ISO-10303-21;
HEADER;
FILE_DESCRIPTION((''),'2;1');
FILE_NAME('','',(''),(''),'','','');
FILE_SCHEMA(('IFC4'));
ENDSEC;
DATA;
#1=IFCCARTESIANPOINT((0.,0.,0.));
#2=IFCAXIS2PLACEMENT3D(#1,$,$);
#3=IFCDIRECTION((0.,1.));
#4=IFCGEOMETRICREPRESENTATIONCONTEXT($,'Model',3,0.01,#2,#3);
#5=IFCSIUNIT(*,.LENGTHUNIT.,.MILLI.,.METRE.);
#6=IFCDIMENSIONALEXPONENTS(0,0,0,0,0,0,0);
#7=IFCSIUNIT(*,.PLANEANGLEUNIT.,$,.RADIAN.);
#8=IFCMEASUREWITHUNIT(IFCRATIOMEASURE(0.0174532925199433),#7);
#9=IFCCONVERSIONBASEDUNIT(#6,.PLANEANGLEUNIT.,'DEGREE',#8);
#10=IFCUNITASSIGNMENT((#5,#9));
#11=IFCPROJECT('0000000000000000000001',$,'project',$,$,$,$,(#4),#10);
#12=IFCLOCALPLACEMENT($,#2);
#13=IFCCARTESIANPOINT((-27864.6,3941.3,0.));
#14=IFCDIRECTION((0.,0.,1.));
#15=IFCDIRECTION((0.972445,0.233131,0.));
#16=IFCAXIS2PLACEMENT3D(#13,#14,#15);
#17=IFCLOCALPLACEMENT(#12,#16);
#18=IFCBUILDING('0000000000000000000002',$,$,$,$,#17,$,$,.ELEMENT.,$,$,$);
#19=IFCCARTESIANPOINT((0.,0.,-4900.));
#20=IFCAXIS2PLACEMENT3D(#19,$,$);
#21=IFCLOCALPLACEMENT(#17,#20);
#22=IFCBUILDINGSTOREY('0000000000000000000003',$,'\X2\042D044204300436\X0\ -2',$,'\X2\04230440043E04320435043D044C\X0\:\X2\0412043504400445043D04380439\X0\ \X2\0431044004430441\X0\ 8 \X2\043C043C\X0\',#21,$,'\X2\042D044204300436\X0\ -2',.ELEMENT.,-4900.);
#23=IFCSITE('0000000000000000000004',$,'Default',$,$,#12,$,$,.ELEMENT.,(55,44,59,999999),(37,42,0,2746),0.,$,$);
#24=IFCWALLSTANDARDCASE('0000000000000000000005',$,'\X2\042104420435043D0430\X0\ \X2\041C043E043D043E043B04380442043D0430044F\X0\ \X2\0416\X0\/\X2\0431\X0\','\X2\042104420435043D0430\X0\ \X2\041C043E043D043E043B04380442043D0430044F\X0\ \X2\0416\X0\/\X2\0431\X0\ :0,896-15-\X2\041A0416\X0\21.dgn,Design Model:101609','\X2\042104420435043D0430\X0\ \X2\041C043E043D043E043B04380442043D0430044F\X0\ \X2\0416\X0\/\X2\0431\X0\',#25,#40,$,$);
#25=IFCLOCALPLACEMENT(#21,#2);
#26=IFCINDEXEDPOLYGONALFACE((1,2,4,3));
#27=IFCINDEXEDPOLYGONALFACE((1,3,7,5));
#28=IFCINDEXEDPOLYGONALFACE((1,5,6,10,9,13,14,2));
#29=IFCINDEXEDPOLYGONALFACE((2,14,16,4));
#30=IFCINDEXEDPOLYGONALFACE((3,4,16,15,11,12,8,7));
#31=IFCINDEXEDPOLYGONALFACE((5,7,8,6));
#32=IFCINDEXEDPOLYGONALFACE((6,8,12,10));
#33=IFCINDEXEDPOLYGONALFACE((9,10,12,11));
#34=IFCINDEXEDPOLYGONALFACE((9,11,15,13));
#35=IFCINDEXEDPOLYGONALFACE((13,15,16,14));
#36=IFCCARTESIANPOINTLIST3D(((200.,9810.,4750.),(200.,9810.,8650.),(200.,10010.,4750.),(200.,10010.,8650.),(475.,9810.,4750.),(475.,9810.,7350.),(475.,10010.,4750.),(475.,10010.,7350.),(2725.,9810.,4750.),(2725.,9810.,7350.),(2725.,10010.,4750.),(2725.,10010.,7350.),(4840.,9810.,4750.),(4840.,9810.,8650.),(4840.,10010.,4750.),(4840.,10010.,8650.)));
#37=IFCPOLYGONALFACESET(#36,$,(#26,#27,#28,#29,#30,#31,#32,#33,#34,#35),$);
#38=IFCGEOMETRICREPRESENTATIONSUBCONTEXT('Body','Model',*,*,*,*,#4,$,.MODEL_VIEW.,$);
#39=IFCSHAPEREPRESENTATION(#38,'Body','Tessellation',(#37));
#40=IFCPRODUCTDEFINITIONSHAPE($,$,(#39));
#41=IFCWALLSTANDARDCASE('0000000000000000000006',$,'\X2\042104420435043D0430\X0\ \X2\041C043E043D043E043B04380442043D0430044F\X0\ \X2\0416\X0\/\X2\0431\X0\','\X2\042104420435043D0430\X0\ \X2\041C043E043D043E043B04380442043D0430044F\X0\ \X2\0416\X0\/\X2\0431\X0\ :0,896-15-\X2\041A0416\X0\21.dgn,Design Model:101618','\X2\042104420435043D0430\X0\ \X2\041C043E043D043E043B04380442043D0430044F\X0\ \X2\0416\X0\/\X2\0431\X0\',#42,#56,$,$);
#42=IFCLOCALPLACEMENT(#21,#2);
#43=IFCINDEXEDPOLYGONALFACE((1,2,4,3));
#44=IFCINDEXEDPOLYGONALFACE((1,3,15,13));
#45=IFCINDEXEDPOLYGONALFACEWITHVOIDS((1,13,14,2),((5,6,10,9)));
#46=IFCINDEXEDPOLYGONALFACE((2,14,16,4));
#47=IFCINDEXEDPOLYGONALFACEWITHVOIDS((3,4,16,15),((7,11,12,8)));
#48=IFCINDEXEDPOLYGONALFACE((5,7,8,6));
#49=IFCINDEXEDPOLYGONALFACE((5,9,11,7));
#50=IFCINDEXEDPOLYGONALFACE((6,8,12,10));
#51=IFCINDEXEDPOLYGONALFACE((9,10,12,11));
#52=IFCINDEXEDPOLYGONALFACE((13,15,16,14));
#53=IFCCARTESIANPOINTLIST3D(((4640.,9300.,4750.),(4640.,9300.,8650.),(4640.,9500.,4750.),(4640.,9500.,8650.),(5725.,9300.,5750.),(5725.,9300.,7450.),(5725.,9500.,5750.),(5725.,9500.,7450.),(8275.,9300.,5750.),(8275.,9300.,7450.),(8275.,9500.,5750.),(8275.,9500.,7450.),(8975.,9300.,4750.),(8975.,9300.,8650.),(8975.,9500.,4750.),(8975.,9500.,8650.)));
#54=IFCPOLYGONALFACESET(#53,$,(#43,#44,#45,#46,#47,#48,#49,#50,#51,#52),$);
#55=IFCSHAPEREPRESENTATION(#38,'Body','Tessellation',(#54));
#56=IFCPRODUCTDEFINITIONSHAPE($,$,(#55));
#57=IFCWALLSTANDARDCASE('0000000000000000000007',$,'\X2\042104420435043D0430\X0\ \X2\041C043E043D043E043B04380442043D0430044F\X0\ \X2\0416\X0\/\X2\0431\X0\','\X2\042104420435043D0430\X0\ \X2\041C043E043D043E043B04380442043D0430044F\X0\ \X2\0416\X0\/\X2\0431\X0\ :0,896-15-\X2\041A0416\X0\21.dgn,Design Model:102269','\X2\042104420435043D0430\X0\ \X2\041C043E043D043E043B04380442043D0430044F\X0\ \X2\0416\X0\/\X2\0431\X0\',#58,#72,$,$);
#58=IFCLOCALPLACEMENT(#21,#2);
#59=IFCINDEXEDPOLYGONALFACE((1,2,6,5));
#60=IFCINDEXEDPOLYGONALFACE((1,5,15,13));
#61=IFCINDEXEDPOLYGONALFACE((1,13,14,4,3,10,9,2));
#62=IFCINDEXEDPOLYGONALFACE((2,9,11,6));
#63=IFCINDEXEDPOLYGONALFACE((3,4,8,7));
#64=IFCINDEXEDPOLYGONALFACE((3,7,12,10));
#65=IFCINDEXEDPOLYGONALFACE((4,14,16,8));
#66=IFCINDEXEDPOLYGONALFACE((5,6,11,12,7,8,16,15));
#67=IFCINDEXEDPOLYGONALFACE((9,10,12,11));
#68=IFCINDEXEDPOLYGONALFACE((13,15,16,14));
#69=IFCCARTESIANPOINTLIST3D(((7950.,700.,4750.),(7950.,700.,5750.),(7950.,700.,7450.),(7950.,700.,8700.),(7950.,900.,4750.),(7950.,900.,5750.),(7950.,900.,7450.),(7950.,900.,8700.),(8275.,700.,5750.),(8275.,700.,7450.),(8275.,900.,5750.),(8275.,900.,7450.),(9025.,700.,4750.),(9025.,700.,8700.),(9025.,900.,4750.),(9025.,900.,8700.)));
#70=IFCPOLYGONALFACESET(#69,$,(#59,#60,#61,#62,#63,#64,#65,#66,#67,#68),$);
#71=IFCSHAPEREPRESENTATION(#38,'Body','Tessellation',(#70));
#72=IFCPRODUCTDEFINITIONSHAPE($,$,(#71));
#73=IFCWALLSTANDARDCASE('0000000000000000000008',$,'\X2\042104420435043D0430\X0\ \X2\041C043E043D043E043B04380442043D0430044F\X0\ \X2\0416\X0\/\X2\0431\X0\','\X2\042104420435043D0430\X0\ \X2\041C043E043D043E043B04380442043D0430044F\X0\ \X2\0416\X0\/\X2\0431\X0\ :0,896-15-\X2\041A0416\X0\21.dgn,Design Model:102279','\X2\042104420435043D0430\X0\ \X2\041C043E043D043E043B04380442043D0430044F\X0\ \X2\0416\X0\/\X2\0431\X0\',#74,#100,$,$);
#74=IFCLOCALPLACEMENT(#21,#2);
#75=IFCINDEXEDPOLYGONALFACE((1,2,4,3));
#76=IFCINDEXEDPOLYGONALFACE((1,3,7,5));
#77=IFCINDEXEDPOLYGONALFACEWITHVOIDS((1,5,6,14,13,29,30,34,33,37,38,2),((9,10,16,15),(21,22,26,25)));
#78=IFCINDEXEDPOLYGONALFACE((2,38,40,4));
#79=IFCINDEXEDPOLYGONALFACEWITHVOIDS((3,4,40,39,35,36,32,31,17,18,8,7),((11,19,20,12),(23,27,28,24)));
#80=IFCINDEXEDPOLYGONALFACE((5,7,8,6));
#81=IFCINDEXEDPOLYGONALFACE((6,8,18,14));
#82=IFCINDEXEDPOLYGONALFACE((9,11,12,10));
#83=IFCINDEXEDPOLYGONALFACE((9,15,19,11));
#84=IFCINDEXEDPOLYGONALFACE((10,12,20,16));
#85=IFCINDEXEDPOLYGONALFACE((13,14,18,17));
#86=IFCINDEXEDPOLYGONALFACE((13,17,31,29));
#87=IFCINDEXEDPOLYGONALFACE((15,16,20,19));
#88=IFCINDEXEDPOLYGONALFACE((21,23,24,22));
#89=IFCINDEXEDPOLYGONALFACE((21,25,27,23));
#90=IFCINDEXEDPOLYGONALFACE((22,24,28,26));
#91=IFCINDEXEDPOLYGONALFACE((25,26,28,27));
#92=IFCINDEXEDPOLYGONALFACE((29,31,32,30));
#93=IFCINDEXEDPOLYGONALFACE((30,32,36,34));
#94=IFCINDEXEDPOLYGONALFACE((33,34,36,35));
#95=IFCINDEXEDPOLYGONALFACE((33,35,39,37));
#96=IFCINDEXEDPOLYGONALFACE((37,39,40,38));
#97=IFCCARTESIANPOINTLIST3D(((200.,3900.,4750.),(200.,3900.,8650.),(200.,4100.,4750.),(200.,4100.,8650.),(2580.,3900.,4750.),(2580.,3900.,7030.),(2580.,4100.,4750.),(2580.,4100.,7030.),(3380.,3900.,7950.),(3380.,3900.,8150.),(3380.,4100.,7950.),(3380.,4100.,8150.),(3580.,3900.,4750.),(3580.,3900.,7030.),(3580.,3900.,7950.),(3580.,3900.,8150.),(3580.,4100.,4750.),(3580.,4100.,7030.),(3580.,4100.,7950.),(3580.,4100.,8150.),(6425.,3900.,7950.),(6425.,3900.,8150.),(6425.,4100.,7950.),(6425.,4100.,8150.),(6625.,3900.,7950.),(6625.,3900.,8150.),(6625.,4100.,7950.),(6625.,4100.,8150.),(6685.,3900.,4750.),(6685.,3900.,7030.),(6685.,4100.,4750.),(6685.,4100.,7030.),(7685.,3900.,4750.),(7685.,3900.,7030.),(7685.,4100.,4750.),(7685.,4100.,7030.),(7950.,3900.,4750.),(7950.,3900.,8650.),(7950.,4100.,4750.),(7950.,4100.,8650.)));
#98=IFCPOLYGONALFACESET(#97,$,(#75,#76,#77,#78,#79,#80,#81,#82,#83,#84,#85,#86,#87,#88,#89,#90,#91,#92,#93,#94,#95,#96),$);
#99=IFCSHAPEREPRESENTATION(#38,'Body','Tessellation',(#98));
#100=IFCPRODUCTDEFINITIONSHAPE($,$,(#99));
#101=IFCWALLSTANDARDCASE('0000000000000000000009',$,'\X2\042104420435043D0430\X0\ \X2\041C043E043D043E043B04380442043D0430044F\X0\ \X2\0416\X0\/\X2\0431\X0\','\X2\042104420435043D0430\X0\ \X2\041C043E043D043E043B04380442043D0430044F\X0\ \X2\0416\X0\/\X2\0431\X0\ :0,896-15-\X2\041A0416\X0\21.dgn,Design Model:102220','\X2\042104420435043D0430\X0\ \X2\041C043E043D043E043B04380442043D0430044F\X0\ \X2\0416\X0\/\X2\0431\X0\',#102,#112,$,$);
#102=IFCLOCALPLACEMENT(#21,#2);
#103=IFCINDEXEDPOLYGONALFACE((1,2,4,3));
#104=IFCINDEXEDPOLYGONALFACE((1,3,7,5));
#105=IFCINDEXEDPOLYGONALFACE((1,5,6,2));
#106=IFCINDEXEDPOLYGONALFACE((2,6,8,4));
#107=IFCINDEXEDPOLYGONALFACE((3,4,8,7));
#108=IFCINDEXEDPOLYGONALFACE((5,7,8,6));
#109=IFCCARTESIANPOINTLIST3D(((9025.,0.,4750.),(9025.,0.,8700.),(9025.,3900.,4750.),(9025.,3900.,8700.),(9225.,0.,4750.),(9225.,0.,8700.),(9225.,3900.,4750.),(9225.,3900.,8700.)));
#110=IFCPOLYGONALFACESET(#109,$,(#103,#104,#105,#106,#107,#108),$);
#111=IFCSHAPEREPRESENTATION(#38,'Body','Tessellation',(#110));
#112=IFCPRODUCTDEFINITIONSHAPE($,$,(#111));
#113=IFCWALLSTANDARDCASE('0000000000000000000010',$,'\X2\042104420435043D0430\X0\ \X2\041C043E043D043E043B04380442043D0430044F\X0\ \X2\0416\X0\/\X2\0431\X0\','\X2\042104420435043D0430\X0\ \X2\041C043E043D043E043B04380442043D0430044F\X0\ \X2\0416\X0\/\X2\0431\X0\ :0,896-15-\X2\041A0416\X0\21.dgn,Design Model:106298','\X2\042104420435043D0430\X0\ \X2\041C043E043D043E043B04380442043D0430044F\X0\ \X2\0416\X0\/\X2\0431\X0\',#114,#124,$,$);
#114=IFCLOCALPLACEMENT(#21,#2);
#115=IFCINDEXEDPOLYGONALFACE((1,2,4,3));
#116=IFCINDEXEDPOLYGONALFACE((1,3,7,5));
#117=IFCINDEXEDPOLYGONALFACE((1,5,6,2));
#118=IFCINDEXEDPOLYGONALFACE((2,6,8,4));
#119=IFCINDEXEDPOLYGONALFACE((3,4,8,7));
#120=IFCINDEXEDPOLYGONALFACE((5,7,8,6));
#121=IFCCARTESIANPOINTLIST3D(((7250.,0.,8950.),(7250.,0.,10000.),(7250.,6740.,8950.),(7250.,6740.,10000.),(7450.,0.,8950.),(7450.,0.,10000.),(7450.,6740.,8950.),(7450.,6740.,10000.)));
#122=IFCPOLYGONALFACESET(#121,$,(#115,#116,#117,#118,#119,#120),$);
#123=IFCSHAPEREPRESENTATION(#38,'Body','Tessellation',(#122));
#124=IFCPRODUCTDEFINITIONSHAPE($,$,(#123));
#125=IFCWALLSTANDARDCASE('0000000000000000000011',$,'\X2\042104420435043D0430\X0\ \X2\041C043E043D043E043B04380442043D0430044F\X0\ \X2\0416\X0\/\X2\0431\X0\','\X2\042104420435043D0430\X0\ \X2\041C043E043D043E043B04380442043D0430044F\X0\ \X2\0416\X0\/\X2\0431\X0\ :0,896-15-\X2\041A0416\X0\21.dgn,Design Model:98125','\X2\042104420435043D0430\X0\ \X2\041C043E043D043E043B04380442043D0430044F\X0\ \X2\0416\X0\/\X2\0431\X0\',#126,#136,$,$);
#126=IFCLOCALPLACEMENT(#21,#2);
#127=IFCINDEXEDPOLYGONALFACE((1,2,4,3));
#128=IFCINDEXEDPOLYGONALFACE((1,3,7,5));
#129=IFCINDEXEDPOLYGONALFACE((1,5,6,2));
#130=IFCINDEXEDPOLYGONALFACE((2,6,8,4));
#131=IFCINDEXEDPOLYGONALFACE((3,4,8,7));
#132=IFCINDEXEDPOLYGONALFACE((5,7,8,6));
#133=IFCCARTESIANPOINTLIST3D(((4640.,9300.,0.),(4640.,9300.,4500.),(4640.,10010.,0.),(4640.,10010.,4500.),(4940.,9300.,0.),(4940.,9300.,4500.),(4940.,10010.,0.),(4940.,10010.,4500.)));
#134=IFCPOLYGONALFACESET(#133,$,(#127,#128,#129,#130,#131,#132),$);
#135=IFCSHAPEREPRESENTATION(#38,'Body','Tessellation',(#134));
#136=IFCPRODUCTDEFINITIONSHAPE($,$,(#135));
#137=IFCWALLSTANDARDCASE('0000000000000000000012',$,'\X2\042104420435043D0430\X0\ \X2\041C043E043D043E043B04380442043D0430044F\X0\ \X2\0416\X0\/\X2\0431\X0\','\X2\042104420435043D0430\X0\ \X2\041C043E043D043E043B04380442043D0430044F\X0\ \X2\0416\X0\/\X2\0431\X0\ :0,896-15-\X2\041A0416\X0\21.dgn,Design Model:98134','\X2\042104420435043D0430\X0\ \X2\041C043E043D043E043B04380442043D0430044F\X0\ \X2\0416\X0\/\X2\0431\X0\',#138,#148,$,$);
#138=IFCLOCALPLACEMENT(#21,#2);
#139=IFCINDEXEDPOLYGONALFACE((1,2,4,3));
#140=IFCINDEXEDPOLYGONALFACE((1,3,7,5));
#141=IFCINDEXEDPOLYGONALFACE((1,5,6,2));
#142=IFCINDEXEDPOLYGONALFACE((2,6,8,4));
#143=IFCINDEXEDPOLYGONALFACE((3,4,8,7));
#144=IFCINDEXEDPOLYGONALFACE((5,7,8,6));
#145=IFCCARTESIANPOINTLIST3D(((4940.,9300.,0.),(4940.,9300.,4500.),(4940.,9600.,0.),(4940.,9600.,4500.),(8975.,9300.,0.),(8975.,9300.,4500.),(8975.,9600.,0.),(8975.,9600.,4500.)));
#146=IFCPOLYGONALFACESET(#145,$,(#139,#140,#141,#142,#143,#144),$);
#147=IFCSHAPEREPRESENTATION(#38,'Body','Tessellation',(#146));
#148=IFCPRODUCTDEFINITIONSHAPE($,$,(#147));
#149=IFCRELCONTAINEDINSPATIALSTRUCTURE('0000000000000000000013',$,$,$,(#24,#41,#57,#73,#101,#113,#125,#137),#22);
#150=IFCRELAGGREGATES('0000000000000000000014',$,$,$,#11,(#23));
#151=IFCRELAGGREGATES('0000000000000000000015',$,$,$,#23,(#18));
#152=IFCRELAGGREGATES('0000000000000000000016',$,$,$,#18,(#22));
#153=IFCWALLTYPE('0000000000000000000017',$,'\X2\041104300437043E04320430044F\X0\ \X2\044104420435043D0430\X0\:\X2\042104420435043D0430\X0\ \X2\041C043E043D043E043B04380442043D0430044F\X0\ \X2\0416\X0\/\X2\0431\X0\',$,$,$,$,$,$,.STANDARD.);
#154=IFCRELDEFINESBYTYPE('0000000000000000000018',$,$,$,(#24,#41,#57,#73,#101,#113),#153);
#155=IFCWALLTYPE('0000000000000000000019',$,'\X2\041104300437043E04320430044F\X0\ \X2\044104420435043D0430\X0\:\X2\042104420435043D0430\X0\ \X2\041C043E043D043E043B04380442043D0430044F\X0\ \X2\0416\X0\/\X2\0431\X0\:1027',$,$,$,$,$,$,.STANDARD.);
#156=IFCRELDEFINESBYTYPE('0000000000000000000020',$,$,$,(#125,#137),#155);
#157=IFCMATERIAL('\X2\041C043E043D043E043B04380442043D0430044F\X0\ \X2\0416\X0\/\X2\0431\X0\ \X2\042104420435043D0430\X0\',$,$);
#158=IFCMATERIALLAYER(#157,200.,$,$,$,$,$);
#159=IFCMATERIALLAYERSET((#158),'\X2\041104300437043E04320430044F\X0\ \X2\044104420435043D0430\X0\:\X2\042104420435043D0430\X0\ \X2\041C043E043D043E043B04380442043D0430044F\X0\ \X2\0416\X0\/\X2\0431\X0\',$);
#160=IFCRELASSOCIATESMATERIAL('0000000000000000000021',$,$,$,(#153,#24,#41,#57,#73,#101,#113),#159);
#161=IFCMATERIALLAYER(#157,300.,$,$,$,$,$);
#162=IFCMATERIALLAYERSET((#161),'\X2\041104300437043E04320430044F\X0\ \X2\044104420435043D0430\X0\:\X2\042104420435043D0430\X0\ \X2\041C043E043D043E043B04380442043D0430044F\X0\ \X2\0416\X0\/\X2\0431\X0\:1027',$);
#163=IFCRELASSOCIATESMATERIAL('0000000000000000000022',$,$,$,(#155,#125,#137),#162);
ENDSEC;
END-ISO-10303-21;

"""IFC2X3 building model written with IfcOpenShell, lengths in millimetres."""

from ifc_helpers import new_model, entity, si_unit, converted_unit, direction, frame, frame_2d, origin, origin_2d_with_axis, place, context, subcontext, project, spatial, rectangle, extrude, material, layer, layer_set, layer_usage, type_object, element, save


model = new_model("IFC2X3")

# Units and contexts
model_context = context("Model", 3, precision=0.01, world=origin(), true_north=direction((0.0, 1.0)))
body_context = subcontext(model_context, "Body", "Model", "MODEL_VIEW")
ifc_project = project(units=[si_unit("LENGTHUNIT", "METRE", prefix="MILLI"), converted_unit("PLANEANGLEUNIT", "DEGREE", entity("IfcRatioMeasure", 0.0174532925199433), si_unit("PLANEANGLEUNIT", "RADIAN"), dimensions=[0, 0, 0, 0, 0, 0, 0])], contexts=[model_context])

# Site, building, storey
site_placement = place(None, origin())
site = spatial("IfcSite", under=ifc_project, at=site_placement, Name="Default", CompositionType="ELEMENT", RefLatitude=(55, 44, 59, 999999), RefLongitude=(37, 42, 0, 2746), RefElevation=0.0)
building_placement = place(site_placement, frame((-27864.6, 3941.3, 0.0), z_axis=(0.0, 0.0, 1.0), x_axis=(0.972445, 0.233131, 0.0)))
building = spatial("IfcBuilding", under=site, at=building_placement, CompositionType="ELEMENT")
storey_placement = place(building_placement, frame((0.0, 0.0, -4900.0)))
storey = spatial("IfcBuildingStorey", under=building, at=storey_placement, Name="Этаж -2", ObjectType="Уровень:Верхний брус 8 мм", LongName="Этаж -2", CompositionType="ELEMENT", Elevation=-4900.0)

# Walls, openings
ifc_material = material(Name="Монолитная Ж/б Стена")
ifc_layer_1 = layer(ifc_material, 200.0)
ifc_layer_set_1 = layer_set([ifc_layer_1], Name="Базовая стена:Стена Монолитная Ж/б")
ifc_layer_usage_1 = layer_usage(ifc_layer_set_1, "AXIS2", "NEGATIVE", 100.0)
wall_type_1 = type_object("IfcWallType", Name="Базовая стена:Стена Монолитная Ж/б", PredefinedType="STANDARD", material=ifc_layer_set_1)
wall_1_placement = place(storey_placement, frame((4840.0, 9910.0, 4750.0), z_axis=(0.0, 0.0, 1.0), x_axis=(-1.0, 0.0, 0.0)))
wall_1 = element("IfcWallStandardCase", 1, at=wall_1_placement, inside=storey, type_object=wall_type_1, material=ifc_layer_usage_1, Name="Стена Монолитная Ж/б", Description="Стена Монолитная Ж/б :0,896-15-КЖ21.dgn,Design Model:101609", ObjectType="Стена Монолитная Ж/б", context=body_context, shape_type="SweptSolid", body=[
    extrude(rectangle(XDim=4640.0, YDim=200.0, at=frame_2d((2320.0, 0.0), x_axis=(-1.0, 0.0))), origin(), (0.0, 0.0, 1.0), 3900.0),
])
opening_1_placement = place(wall_1_placement, origin())
element("IfcOpeningElement", 2, at=opening_1_placement, cuts=wall_1, ObjectType="Opening", context=body_context, shape_type="SweptSolid", body=[
    extrude(rectangle(XDim=2600.0, YDim=2250.0, at=origin_2d_with_axis()), frame((3240.0, -100.0, 1300.0), z_axis=(0.0, 1.0, 0.0), x_axis=(0.0, 0.0, -1.0)), (0.0, 0.0, 1.0), 200.0),
])
wall_2_placement = place(storey_placement, frame((8975.0, 9400.0, 4750.0), z_axis=(0.0, 0.0, 1.0), x_axis=(-1.0, 0.0, 0.0)))
wall_2 = element("IfcWallStandardCase", 3, at=wall_2_placement, inside=storey, type_object=wall_type_1, material=ifc_layer_usage_1, Name="Стена Монолитная Ж/б", Description="Стена Монолитная Ж/б :0,896-15-КЖ21.dgn,Design Model:101618", ObjectType="Стена Монолитная Ж/б", context=body_context, shape_type="SweptSolid", body=[
    extrude(rectangle(XDim=4335.0, YDim=200.0, at=frame_2d((2167.5, 0.0), x_axis=(-1.0, 0.0))), origin(), (0.0, 0.0, 1.0), 3900.0),
])
opening_2_placement = place(wall_2_placement, origin())
element("IfcOpeningElement", 4, at=opening_2_placement, cuts=wall_2, ObjectType="Opening", context=body_context, shape_type="SweptSolid", body=[
    extrude(rectangle(XDim=1700.0, YDim=2550.0, at=origin_2d_with_axis()), frame((1975.0, -100.0, 1850.0), z_axis=(0.0, 1.0, 0.0), x_axis=(0.0, 0.0, -1.0)), (0.0, 0.0, 1.0), 200.0),
])
wall_3_placement = place(storey_placement, frame((9025.0, 800.0, 4750.0), z_axis=(0.0, 0.0, 1.0), x_axis=(-1.0, 0.0, 0.0)))
wall_3 = element("IfcWallStandardCase", 5, at=wall_3_placement, inside=storey, type_object=wall_type_1, material=ifc_layer_usage_1, Name="Стена Монолитная Ж/б", Description="Стена Монолитная Ж/б :0,896-15-КЖ21.dgn,Design Model:102269", ObjectType="Стена Монолитная Ж/б", context=body_context, shape_type="SweptSolid", body=[
    extrude(rectangle(XDim=1075.0, YDim=200.0, at=frame_2d((537.5, 0.0), x_axis=(-1.0, 0.0))), origin(), (0.0, 0.0, 1.0), 3950.0),
])
opening_3_placement = place(wall_3_placement, origin())
element("IfcOpeningElement", 6, at=opening_3_placement, cuts=wall_3, ObjectType="Opening", context=body_context, shape_type="SweptSolid", body=[
    extrude(rectangle(XDim=1700.0, YDim=325.0, at=origin_2d_with_axis()), frame((912.5, -100.0, 1850.0), z_axis=(0.0, 1.0, 0.0), x_axis=(0.0, 0.0, -1.0)), (0.0, 0.0, 1.0), 200.0),
])

# Wall, openings
wall_4_placement = place(storey_placement, frame((7950.0, 4000.0, 4750.0), z_axis=(0.0, 0.0, 1.0), x_axis=(-1.0, 0.0, 0.0)))
wall_4 = element("IfcWallStandardCase", 7, at=wall_4_placement, inside=storey, type_object=wall_type_1, material=ifc_layer_usage_1, Name="Стена Монолитная Ж/б", Description="Стена Монолитная Ж/б :0,896-15-КЖ21.dgn,Design Model:102279", ObjectType="Стена Монолитная Ж/б", context=body_context, shape_type="SweptSolid", body=[
    extrude(rectangle(XDim=7750.0, YDim=200.0, at=frame_2d((3875.0, 0.0), x_axis=(-1.0, 0.0))), origin(), (0.0, 0.0, 1.0), 3900.0),
])
placement_1 = place(wall_4_placement, origin())
element("IfcOpeningElement", 8, at=placement_1, cuts=wall_4, ObjectType="Opening", context=body_context, shape_type="SweptSolid", body=[
    extrude(rectangle(XDim=2280.0, YDim=1000.0, at=origin_2d_with_axis()), frame((4870.0, -100.0, 1140.0), z_axis=(0.0, 1.0, 0.0), x_axis=(0.0, 0.0, -1.0)), (0.0, 0.0, 1.0), 200.0),
])
element("IfcOpeningElement", 9, at=placement_1, cuts=wall_4, ObjectType="Opening", context=body_context, shape_type="SweptSolid", body=[
    extrude(rectangle(XDim=2280.0, YDim=1000.0, at=origin_2d_with_axis()), frame((765.0, -100.0, 1140.0), z_axis=(0.0, 1.0, 0.0), x_axis=(0.0, 0.0, -1.0)), (0.0, 0.0, 1.0), 200.0),
])
element("IfcOpeningElement", 10, at=placement_1, cuts=wall_4, ObjectType="Opening", context=body_context, shape_type="SweptSolid", body=[
    extrude(rectangle(XDim=200.0, YDim=200.0, at=origin_2d_with_axis()), frame((4470.0, -100.0, 3300.0), z_axis=(0.0, 1.0, 0.0), x_axis=(0.0, 0.0, -1.0)), (0.0, 0.0, 1.0), 200.0),
])
element("IfcOpeningElement", 11, at=placement_1, cuts=wall_4, ObjectType="Opening", context=body_context, shape_type="SweptSolid", body=[
    extrude(rectangle(XDim=200.0, YDim=200.0, at=origin_2d_with_axis()), frame((1425.0, -100.0, 3300.0), z_axis=(0.0, 1.0, 0.0), x_axis=(0.0, 0.0, -1.0)), (0.0, 0.0, 1.0), 200.0),
])

# Walls
wall_5_placement = place(storey_placement, frame((9125.0, 3900.0, 4750.0), z_axis=(0.0, 0.0, 1.0), x_axis=(0.0, -1.0, 0.0)))
element("IfcWallStandardCase", 12, at=wall_5_placement, inside=storey, type_object=wall_type_1, material=ifc_layer_usage_1, Name="Стена Монолитная Ж/б", Description="Стена Монолитная Ж/б :0,896-15-КЖ21.dgn,Design Model:102220", ObjectType="Стена Монолитная Ж/б", context=body_context, shape_type="SweptSolid", body=[
    extrude(rectangle(XDim=3900.0, YDim=200.0, at=frame_2d((1950.0, 0.0), x_axis=(-1.0, 0.0))), origin(), (0.0, 0.0, 1.0), 3950.0),
])
wall_6_placement = place(storey_placement, frame((7350.0, 6740.0, 8950.0), z_axis=(0.0, 0.0, 1.0), x_axis=(0.0, -1.0, 0.0)))
element("IfcWallStandardCase", 13, at=wall_6_placement, inside=storey, type_object=wall_type_1, material=ifc_layer_usage_1, Name="Стена Монолитная Ж/б", Description="Стена Монолитная Ж/б :0,896-15-КЖ21.dgn,Design Model:106298", ObjectType="Стена Монолитная Ж/б", context=body_context, shape_type="SweptSolid", body=[
    extrude(rectangle(XDim=6740.0, YDim=200.0, at=frame_2d((3370.0, 0.0), x_axis=(-1.0, 0.0))), origin(), (0.0, 0.0, 1.0), 1050.0),
])
ifc_layer_2 = layer(ifc_material, 300.0)
ifc_layer_set_2 = layer_set([ifc_layer_2], Name="Базовая стена:Стена Монолитная Ж/б:1027")
ifc_layer_usage_2 = layer_usage(ifc_layer_set_2, "AXIS2", "NEGATIVE", 150.0)
wall_type_2 = type_object("IfcWallType", Name="Базовая стена:Стена Монолитная Ж/б:1027", PredefinedType="STANDARD", material=ifc_layer_set_2)
wall_7_placement = place(storey_placement, frame((4790.0, 9300.0, 0.0), z_axis=(0.0, 0.0, 1.0), x_axis=(0.0, 1.0, 0.0)))
element("IfcWallStandardCase", 14, at=wall_7_placement, inside=storey, type_object=wall_type_2, material=ifc_layer_usage_2, Name="Стена Монолитная Ж/б", Description="Стена Монолитная Ж/б :0,896-15-КЖ21.dgn,Design Model:98125", ObjectType="Стена Монолитная Ж/б", context=body_context, shape_type="SweptSolid", body=[
    extrude(rectangle(XDim=710.0, YDim=300.0, at=frame_2d((355.0, 0.0), x_axis=(-1.0, 0.0))), origin(), (0.0, 0.0, 1.0), 4500.0),
])
wall_8_placement = place(storey_placement, frame((8975.0, 9450.0, 0.0), z_axis=(0.0, 0.0, 1.0), x_axis=(-1.0, 0.0, 0.0)))
element("IfcWallStandardCase", 15, at=wall_8_placement, inside=storey, type_object=wall_type_2, material=ifc_layer_usage_2, Name="Стена Монолитная Ж/б", Description="Стена Монолитная Ж/б :0,896-15-КЖ21.dgn,Design Model:98134", ObjectType="Стена Монолитная Ж/б", context=body_context, shape_type="SweptSolid", body=[
    extrude(rectangle(XDim=4035.0, YDim=300.0, at=frame_2d((2017.5, 0.0), x_axis=(-1.0, 0.0))), origin(), (0.0, 0.0, 1.0), 4500.0),
])

save(model, "model.ifc")
